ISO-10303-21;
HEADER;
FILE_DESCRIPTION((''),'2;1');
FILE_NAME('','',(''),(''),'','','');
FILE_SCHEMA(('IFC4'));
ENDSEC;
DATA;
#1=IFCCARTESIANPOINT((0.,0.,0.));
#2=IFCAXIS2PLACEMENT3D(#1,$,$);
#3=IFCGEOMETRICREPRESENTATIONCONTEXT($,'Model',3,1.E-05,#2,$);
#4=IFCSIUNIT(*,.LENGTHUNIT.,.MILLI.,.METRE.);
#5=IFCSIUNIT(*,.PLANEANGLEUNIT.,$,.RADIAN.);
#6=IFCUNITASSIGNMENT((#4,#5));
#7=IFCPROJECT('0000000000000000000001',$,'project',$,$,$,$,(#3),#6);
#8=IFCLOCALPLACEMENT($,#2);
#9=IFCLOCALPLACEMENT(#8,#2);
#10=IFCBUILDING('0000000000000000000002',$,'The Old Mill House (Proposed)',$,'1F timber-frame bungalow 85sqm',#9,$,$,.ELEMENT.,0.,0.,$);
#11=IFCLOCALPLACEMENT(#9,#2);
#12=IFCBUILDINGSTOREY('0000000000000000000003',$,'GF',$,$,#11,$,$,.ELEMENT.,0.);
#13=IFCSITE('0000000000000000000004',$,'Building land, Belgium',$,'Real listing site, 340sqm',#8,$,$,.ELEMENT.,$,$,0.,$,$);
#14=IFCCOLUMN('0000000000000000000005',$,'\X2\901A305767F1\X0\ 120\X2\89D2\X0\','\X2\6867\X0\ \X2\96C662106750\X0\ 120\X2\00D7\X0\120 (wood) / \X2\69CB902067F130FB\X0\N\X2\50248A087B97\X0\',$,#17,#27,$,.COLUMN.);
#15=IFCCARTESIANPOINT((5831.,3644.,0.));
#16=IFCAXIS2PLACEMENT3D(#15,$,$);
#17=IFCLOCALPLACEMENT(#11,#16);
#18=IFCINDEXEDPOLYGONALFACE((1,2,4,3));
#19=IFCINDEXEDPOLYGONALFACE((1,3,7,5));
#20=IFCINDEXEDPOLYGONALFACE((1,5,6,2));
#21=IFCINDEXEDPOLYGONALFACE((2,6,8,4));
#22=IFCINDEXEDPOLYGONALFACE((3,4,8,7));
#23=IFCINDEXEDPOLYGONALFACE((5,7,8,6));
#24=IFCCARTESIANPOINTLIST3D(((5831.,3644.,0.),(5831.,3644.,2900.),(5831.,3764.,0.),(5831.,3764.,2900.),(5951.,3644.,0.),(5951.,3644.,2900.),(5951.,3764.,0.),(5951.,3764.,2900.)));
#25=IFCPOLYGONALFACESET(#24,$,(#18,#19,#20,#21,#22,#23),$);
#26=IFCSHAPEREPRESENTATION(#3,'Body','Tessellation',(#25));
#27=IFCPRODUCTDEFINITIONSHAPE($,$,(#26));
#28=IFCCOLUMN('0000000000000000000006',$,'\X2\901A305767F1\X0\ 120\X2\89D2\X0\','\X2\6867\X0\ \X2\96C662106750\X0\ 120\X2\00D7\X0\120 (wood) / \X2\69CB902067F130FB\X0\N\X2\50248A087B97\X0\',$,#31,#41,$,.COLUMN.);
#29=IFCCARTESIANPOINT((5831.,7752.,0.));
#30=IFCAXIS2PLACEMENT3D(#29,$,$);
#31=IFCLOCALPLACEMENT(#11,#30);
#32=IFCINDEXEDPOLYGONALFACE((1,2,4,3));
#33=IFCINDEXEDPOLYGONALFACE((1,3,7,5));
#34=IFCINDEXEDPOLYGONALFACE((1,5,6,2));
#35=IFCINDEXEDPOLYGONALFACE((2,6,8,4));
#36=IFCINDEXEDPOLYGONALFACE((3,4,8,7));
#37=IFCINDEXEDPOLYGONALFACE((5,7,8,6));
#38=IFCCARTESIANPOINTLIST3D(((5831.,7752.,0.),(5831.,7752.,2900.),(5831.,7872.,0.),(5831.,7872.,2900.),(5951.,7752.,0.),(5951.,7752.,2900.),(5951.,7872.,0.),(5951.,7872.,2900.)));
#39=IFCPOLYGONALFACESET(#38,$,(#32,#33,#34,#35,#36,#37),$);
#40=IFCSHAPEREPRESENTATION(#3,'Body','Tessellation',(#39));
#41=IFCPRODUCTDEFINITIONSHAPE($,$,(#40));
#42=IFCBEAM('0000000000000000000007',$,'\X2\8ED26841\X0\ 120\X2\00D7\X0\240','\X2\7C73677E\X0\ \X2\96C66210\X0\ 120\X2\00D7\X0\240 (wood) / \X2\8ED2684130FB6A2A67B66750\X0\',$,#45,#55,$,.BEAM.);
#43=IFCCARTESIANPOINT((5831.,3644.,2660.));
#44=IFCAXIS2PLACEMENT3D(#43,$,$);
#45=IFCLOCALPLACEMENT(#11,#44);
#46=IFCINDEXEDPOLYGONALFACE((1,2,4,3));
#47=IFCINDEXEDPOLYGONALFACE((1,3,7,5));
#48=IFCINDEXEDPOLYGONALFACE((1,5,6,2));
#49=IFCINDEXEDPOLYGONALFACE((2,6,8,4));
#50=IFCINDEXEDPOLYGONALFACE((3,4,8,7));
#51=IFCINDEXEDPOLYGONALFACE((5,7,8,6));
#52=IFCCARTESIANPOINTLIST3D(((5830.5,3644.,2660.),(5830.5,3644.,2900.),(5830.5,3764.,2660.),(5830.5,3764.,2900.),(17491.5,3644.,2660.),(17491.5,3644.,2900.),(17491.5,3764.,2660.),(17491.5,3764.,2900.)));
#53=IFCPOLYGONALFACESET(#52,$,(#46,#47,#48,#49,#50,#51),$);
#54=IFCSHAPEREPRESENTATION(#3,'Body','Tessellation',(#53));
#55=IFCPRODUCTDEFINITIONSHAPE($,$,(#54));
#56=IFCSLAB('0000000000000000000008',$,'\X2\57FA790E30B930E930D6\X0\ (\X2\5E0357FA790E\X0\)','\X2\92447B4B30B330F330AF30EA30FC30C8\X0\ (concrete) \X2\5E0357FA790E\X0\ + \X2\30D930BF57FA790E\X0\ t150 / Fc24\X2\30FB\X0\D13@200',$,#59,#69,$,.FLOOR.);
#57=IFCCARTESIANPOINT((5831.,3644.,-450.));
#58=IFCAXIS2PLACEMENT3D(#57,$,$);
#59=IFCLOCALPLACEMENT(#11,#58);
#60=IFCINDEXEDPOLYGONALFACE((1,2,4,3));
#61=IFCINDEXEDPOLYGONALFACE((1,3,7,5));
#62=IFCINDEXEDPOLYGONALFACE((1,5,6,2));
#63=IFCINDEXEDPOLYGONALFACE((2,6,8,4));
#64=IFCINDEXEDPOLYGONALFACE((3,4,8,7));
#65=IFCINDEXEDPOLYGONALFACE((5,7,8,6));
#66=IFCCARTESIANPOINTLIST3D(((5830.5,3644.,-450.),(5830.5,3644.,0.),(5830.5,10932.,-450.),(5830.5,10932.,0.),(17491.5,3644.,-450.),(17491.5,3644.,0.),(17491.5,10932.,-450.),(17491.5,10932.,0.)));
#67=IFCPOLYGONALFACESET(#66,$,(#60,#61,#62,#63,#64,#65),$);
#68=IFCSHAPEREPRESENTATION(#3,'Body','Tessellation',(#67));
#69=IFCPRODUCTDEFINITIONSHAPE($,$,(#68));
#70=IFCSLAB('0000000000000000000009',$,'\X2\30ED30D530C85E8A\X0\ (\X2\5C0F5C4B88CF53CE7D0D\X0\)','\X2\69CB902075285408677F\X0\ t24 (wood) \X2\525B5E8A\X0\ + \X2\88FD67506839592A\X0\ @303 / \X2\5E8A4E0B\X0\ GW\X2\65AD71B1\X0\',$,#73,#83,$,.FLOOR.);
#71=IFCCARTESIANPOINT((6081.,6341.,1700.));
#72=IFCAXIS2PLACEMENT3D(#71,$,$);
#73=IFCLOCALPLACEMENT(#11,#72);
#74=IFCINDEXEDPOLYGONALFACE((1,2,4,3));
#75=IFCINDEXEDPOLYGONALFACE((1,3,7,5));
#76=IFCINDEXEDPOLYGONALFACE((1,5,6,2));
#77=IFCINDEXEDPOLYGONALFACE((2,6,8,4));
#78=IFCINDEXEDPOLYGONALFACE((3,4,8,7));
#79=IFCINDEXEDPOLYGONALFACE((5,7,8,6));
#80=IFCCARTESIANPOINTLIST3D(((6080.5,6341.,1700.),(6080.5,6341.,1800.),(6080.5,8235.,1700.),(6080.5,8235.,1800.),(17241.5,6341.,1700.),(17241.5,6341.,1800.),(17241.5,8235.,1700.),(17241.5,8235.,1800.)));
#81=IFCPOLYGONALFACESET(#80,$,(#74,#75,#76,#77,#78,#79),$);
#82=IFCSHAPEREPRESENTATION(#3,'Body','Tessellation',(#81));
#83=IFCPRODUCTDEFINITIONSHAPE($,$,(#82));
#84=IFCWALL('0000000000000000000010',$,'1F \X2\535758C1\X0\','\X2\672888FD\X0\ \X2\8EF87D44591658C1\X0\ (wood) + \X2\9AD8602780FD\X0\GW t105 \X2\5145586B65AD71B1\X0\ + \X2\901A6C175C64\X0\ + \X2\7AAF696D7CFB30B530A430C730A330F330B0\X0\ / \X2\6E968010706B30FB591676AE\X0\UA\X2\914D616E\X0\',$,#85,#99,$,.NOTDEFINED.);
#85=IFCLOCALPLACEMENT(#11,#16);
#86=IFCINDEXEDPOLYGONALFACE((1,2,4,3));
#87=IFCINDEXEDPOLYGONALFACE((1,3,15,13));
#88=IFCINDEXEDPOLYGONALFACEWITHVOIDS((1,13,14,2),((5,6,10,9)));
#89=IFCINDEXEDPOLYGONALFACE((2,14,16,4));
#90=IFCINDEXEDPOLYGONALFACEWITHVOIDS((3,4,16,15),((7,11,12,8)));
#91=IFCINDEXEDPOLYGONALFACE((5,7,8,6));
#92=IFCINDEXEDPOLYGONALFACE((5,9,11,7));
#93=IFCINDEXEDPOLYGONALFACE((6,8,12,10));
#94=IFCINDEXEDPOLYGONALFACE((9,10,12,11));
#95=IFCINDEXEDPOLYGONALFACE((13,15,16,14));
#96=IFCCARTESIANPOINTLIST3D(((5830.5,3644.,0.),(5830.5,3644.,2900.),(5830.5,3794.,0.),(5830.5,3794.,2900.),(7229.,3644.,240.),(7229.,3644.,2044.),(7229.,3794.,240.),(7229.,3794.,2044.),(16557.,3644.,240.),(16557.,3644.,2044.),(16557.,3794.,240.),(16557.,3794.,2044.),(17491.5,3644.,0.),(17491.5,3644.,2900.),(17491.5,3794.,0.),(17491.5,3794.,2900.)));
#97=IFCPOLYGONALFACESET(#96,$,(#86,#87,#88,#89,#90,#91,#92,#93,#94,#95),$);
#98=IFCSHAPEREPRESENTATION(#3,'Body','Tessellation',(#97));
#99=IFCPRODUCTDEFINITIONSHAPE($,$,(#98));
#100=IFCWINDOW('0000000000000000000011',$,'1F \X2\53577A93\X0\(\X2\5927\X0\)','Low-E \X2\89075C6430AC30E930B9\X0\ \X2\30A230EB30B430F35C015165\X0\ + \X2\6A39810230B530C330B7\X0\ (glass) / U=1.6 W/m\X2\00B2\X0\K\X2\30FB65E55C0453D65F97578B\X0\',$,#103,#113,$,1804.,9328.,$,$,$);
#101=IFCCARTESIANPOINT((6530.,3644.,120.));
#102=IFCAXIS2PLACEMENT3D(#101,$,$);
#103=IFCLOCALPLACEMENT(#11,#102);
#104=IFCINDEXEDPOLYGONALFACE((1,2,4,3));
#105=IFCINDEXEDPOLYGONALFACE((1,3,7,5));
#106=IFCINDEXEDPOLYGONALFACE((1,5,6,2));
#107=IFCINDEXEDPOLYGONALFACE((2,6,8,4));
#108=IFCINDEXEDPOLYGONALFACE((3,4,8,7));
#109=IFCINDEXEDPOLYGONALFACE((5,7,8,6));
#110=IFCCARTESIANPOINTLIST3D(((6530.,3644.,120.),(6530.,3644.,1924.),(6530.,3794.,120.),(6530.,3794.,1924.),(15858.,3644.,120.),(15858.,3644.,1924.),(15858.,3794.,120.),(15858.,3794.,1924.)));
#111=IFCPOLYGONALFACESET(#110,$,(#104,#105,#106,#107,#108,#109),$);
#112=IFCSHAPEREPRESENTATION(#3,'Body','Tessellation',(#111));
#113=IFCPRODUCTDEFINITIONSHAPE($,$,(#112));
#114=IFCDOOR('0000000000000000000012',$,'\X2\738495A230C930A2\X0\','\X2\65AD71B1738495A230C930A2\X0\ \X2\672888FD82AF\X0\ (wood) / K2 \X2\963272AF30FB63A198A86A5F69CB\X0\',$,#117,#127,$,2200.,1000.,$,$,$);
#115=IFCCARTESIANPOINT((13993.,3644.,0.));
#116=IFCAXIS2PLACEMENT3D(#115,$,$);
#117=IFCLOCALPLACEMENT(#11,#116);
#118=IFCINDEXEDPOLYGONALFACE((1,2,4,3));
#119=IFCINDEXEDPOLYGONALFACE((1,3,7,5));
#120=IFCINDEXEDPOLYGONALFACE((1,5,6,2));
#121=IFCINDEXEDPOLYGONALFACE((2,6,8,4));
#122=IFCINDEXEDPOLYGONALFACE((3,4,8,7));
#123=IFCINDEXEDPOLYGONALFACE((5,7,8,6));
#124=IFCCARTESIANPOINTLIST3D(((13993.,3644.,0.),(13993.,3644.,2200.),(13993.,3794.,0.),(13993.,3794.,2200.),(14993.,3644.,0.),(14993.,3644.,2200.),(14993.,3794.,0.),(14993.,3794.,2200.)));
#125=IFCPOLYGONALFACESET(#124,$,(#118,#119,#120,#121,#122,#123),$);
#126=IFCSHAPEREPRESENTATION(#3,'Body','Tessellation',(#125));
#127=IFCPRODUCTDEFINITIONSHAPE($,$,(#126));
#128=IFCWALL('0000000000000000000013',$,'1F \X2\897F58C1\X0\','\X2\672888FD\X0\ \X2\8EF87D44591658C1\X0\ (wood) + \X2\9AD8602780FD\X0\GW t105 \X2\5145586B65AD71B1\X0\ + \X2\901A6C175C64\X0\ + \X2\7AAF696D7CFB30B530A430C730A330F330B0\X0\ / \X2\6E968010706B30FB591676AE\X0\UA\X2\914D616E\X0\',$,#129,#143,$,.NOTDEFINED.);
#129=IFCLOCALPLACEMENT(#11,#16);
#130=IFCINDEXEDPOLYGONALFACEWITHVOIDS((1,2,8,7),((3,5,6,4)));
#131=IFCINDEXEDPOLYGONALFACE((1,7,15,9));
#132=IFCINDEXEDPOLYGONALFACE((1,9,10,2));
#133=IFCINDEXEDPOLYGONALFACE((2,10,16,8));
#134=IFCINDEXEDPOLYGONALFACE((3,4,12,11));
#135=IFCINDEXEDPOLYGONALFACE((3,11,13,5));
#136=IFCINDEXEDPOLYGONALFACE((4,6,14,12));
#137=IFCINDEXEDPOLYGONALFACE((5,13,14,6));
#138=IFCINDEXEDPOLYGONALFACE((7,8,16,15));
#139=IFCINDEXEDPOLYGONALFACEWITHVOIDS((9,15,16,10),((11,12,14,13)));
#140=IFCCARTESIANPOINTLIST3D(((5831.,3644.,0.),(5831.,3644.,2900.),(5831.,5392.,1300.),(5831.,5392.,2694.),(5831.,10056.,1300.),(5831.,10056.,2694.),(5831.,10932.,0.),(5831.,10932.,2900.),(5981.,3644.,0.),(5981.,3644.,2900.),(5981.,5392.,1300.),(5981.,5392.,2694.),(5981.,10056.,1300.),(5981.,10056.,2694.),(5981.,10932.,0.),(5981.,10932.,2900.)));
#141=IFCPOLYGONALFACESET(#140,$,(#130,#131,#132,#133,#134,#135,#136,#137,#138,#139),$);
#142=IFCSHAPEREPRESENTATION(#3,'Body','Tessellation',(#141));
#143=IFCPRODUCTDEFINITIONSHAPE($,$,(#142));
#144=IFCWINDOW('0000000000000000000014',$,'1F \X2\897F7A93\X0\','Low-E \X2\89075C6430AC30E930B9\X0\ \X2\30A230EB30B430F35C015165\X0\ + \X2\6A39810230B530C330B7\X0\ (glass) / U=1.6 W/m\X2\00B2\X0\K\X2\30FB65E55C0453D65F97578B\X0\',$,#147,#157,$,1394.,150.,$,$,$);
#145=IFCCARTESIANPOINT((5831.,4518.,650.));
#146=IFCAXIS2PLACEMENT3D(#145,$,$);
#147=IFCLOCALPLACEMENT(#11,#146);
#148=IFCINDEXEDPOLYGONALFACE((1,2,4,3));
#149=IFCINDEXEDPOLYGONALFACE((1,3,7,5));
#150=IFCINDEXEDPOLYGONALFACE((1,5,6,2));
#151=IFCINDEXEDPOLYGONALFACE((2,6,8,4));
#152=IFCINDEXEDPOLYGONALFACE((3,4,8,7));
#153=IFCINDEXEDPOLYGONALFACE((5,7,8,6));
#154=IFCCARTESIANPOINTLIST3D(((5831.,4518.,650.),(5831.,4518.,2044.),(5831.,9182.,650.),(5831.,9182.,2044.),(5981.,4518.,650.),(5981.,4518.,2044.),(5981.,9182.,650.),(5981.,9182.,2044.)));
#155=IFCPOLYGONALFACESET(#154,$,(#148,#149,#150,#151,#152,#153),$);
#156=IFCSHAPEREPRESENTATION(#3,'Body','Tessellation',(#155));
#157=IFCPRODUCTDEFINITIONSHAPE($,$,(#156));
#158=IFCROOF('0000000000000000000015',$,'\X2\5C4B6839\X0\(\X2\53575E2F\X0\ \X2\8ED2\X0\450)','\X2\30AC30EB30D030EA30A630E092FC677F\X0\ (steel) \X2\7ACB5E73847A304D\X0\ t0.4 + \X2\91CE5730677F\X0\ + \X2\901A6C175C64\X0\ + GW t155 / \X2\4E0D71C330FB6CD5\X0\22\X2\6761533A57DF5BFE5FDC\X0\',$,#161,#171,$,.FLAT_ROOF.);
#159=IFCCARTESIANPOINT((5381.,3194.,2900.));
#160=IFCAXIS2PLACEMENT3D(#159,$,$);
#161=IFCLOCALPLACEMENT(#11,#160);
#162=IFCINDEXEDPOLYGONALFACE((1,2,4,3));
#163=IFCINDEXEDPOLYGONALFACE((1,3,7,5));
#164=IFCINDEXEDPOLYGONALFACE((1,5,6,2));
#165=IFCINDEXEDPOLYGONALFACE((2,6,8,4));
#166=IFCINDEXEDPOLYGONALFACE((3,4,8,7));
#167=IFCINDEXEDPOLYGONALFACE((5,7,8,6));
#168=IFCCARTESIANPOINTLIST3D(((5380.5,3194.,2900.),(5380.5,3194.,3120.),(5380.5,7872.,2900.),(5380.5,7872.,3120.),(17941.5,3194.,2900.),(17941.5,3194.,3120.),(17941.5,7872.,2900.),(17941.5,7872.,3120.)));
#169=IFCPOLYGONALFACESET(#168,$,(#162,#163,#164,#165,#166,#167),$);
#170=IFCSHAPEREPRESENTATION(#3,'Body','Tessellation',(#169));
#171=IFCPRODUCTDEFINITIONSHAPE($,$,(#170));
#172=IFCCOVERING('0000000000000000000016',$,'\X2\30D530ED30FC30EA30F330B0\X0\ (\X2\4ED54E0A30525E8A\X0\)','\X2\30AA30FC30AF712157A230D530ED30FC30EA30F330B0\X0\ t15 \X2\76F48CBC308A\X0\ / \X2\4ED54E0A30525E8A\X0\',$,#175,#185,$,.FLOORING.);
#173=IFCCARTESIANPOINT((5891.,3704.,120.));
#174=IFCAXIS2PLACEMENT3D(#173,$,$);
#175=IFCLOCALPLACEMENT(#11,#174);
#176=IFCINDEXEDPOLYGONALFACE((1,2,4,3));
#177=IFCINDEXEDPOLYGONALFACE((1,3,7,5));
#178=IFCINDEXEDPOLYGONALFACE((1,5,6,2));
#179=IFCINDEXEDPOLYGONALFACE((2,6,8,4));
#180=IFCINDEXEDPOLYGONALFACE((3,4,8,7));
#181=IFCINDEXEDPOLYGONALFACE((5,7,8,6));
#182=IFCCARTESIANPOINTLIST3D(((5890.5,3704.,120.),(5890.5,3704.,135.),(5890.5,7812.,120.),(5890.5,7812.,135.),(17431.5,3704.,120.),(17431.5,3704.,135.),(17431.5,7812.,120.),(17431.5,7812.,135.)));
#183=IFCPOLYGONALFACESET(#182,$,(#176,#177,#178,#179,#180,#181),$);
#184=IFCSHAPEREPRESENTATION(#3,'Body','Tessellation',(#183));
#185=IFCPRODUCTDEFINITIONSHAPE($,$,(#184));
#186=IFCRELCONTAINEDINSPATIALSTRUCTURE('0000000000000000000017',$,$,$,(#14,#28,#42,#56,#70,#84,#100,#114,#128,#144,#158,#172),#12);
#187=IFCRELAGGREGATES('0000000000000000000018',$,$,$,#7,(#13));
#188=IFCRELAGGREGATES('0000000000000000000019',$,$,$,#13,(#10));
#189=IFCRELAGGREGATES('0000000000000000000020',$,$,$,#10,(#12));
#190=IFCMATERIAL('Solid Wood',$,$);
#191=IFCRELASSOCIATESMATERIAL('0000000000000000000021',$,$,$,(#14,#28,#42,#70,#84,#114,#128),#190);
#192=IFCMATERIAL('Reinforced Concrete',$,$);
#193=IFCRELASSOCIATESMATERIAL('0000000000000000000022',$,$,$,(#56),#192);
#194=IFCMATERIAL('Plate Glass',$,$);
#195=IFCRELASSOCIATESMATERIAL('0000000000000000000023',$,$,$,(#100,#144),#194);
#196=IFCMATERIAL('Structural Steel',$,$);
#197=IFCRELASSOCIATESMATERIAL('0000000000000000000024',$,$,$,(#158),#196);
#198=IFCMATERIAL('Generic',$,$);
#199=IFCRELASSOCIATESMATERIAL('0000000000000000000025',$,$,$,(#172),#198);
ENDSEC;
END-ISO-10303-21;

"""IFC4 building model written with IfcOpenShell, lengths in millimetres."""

from ifc_helpers import new_model, si_unit, frame, frame_2d, origin, place, context, project, spatial, rectangle, extrude, material, element, fill, save


model = new_model("IFC4")

# Units and contexts
model_context = context("Model", 3, precision=1e-05, world=origin())
ifc_project = project(units=[si_unit("LENGTHUNIT", "METRE", prefix="MILLI"), si_unit("PLANEANGLEUNIT", "RADIAN")], contexts=[model_context])

# Site, building, storey
site_placement = place(None, origin())
site = spatial("IfcSite", under=ifc_project, at=site_placement, Name="Building land, Belgium", ObjectType="Real listing site, 340sqm", CompositionType="ELEMENT", RefElevation=0.0)
building_placement = place(site_placement, origin())
building = spatial("IfcBuilding", under=site, at=building_placement, Name="The Old Mill House (Proposed)", ObjectType="1F timber-frame bungalow 85sqm", CompositionType="ELEMENT", ElevationOfRefHeight=0.0, ElevationOfTerrain=0.0)
storey_placement = place(building_placement, origin())
storey = spatial("IfcBuildingStorey", under=building, at=storey_placement, Name="GF", CompositionType="ELEMENT", Elevation=0.0)

# Columns
ifc_material_1 = material(Name="Solid Wood")
column_1_placement = place(storey_placement, frame((5831.0, 3644.0, 0.0)))
element("IfcColumn", 1, at=column_1_placement, inside=storey, material=ifc_material_1, Name="通し柱 120角", Description="桧 集成材 120×120 (wood) / 構造柱・N値計算", PredefinedType="COLUMN", context=model_context, shape_type="SweptSolid", body=[
    extrude(rectangle(XDim=120.0, YDim=120.0, at=frame_2d((60.0, 60.0))), frame((5831.0, 3644.0, 0.0)), (0.0, 0.0, 1.0), 2900.0),
])
column_2_placement = place(storey_placement, frame((5831.0, 7752.0, 0.0)))
element("IfcColumn", 2, at=column_2_placement, inside=storey, material=ifc_material_1, Name="通し柱 120角", Description="桧 集成材 120×120 (wood) / 構造柱・N値計算", PredefinedType="COLUMN", context=model_context, shape_type="SweptSolid", body=[
    extrude(rectangle(XDim=120.0, YDim=120.0, at=frame_2d((60.0, 60.0))), frame((5831.0, 7752.0, 0.0)), (0.0, 0.0, 1.0), 2900.0),
])

# Beam
beam_1_placement = place(storey_placement, frame((5831.0, 3644.0, 2660.0)))
element("IfcBeam", 3, at=beam_1_placement, inside=storey, material=ifc_material_1, Name="軒桁 120×240", Description="米松 集成 120×240 (wood) / 軒桁・横架材", PredefinedType="BEAM", context=model_context, shape_type="SweptSolid", body=[
    extrude(rectangle(XDim=11661.0, YDim=120.0, at=frame_2d((5830.0, 60.0))), frame((5831.0, 3644.0, 2660.0)), (0.0, 0.0, 1.0), 240.0),
])

# Slabs
ifc_material_2 = material(Name="Reinforced Concrete")
slab_1_placement = place(storey_placement, frame((5831.0, 3644.0, -450.0)))
element("IfcSlab", 4, at=slab_1_placement, inside=storey, material=ifc_material_2, Name="基礎スラブ (布基礎)", Description="鉄筋コンクリート (concrete) 布基礎 + ベタ基礎 t150 / Fc24・D13@200", PredefinedType="FLOOR", context=model_context, shape_type="SweptSolid", body=[
    extrude(rectangle(XDim=11661.0, YDim=7288.0, at=frame_2d((5830.0, 3644.0))), frame((5831.0, 3644.0, -450.0)), (0.0, 0.0, 1.0), 450.0),
])
slab_2_placement = place(storey_placement, frame((6081.0, 6341.0, 1700.0)))
element("IfcSlab", 5, at=slab_2_placement, inside=storey, material=ifc_material_1, Name="ロフト床 (小屋裏収納)", Description="構造用合板 t24 (wood) 剛床 + 製材根太 @303 / 床下 GW断熱", PredefinedType="FLOOR", context=model_context, shape_type="SweptSolid", body=[
    extrude(rectangle(XDim=11161.0, YDim=1894.0, at=frame_2d((5580.0, 947.0))), frame((6081.0, 6341.0, 1700.0)), (0.0, 0.0, 1.0), 100.0),
])

# Wall, openings, window, door
wall_1_placement = place(storey_placement, frame((5831.0, 3644.0, 0.0)))
wall_1 = element("IfcWall", 6, at=wall_1_placement, inside=storey, material=ifc_material_1, Name="1F 南壁", Description="木製 軸組外壁 (wood) + 高性能GW t105 充填断熱 + 通気層 + 窯業系サイディング / 準耐火・外皮UA配慮", PredefinedType="NOTDEFINED", context=model_context, shape_type="SweptSolid", body=[
    extrude(rectangle(XDim=11661.0, YDim=150.0, at=frame_2d((5830.0, 75.0))), frame((5831.0, 3644.0, 0.0)), (0.0, 0.0, 1.0), 2900.0),
])
opening_1_placement = place(storey_placement, frame((6530.0, 3644.0, 120.0)))
opening_1 = element("IfcOpeningElement", 7, at=opening_1_placement, cuts=wall_1, PredefinedType="NOTDEFINED", context=model_context, shape_type="SweptSolid", body=[
    extrude(rectangle(XDim=9328.0, YDim=150.0, at=frame_2d((4664.0, 75.0))), frame((6530.0, 3644.0, 120.0)), (0.0, 0.0, 1.0), 1804.0),
])
opening_2_placement = place(storey_placement, frame((13993.0, 3644.0, 0.0)))
opening_2 = element("IfcOpeningElement", 8, at=opening_2_placement, cuts=wall_1, PredefinedType="NOTDEFINED", context=model_context, shape_type="SweptSolid", body=[
    extrude(rectangle(XDim=1000.0, YDim=150.0, at=frame_2d((500.0, 75.0))), frame((13993.0, 3644.0, 0.0)), (0.0, 0.0, 1.0), 2200.0),
])
ifc_material_3 = material(Name="Plate Glass")
window_1_placement = place(storey_placement, frame((6530.0, 3644.0, 120.0)))
window_1 = element("IfcWindow", 9, at=window_1_placement, inside=storey, material=ifc_material_3, Name="1F 南窓(大)", Description="Low-E 複層ガラス アルゴン封入 + 樹脂サッシ (glass) / U=1.6 W/m²K・日射取得型", OverallHeight=1804.0, OverallWidth=9328.0, context=model_context, shape_type="SweptSolid", body=[
    extrude(rectangle(XDim=9328.0, YDim=150.0, at=frame_2d((4664.0, 75.0))), frame((6530.0, 3644.0, 120.0)), (0.0, 0.0, 1.0), 1804.0),
])
fill(opening_1, window_1)
door_placement = place(storey_placement, frame((13993.0, 3644.0, 0.0)))
door = element("IfcDoor", 10, at=door_placement, inside=storey, material=ifc_material_1, Name="玄関ドア", Description="断熱玄関ドア 木製芯 (wood) / K2 防犯・採風機構", OverallHeight=2200.0, OverallWidth=1000.0, context=model_context, shape_type="SweptSolid", body=[
    extrude(rectangle(XDim=1000.0, YDim=150.0, at=frame_2d((500.0, 75.0))), frame((13993.0, 3644.0, 0.0)), (0.0, 0.0, 1.0), 2200.0),
])
fill(opening_2, door)

# Wall, opening, window
wall_2_placement = place(storey_placement, frame((5831.0, 3644.0, 0.0)))
wall_2 = element("IfcWall", 11, at=wall_2_placement, inside=storey, material=ifc_material_1, Name="1F 西壁", Description="木製 軸組外壁 (wood) + 高性能GW t105 充填断熱 + 通気層 + 窯業系サイディング / 準耐火・外皮UA配慮", PredefinedType="NOTDEFINED", context=model_context, shape_type="SweptSolid", body=[
    extrude(rectangle(XDim=150.0, YDim=7288.0, at=frame_2d((75.0, 3644.0))), frame((5831.0, 3644.0, 0.0)), (0.0, 0.0, 1.0), 2900.0),
])
opening_3_placement = place(storey_placement, frame((5831.0, 4518.0, 650.0)))
opening_3 = element("IfcOpeningElement", 12, at=opening_3_placement, cuts=wall_2, PredefinedType="NOTDEFINED", context=model_context, shape_type="SweptSolid", body=[
    extrude(rectangle(XDim=150.0, YDim=4664.0, at=frame_2d((75.0, 2332.0))), frame((5831.0, 4518.0, 650.0)), (0.0, 0.0, 1.0), 1394.0),
])
window_2_placement = place(storey_placement, frame((5831.0, 4518.0, 650.0)))
window_2 = element("IfcWindow", 13, at=window_2_placement, inside=storey, material=ifc_material_3, Name="1F 西窓", Description="Low-E 複層ガラス アルゴン封入 + 樹脂サッシ (glass) / U=1.6 W/m²K・日射取得型", OverallHeight=1394.0, OverallWidth=150.0, context=model_context, shape_type="SweptSolid", body=[
    extrude(rectangle(XDim=150.0, YDim=4664.0, at=frame_2d((75.0, 2332.0))), frame((5831.0, 4518.0, 650.0)), (0.0, 0.0, 1.0), 1394.0),
])
fill(opening_3, window_2)

# Roof
ifc_material_4 = material(Name="Structural Steel")
roof_placement = place(storey_placement, frame((5381.0, 3194.0, 2900.0)))
element("IfcRoof", 14, at=roof_placement, inside=storey, material=ifc_material_4, Name="屋根(南帯 軒450)", Description="ガルバリウム鋼板 (steel) 立平葺き t0.4 + 野地板 + 通気層 + GW t155 / 不燃・法22条区域対応", PredefinedType="FLAT_ROOF", context=model_context, shape_type="SweptSolid", body=[
    extrude(rectangle(XDim=12561.0, YDim=4678.0, at=frame_2d((6280.0, 2339.0))), frame((5381.0, 3194.0, 2900.0)), (0.0, 0.0, 1.0), 220.0),
])

# Covering
ifc_material_5 = material(Name="Generic")
covering_1_placement = place(storey_placement, frame((5891.0, 3704.0, 120.0)))
element("IfcCovering", 15, at=covering_1_placement, inside=storey, material=ifc_material_5, Name="フローリング (仕上げ床)", Description="オーク無垢フローリング t15 直貼り / 仕上げ床", PredefinedType="FLOORING", context=model_context, shape_type="SweptSolid", body=[
    extrude(rectangle(XDim=11541.0, YDim=4108.0, at=frame_2d((5770.0, 2054.0))), frame((5891.0, 3704.0, 120.0)), (0.0, 0.0, 1.0), 15.0),
])

save(model, "model.ifc")
